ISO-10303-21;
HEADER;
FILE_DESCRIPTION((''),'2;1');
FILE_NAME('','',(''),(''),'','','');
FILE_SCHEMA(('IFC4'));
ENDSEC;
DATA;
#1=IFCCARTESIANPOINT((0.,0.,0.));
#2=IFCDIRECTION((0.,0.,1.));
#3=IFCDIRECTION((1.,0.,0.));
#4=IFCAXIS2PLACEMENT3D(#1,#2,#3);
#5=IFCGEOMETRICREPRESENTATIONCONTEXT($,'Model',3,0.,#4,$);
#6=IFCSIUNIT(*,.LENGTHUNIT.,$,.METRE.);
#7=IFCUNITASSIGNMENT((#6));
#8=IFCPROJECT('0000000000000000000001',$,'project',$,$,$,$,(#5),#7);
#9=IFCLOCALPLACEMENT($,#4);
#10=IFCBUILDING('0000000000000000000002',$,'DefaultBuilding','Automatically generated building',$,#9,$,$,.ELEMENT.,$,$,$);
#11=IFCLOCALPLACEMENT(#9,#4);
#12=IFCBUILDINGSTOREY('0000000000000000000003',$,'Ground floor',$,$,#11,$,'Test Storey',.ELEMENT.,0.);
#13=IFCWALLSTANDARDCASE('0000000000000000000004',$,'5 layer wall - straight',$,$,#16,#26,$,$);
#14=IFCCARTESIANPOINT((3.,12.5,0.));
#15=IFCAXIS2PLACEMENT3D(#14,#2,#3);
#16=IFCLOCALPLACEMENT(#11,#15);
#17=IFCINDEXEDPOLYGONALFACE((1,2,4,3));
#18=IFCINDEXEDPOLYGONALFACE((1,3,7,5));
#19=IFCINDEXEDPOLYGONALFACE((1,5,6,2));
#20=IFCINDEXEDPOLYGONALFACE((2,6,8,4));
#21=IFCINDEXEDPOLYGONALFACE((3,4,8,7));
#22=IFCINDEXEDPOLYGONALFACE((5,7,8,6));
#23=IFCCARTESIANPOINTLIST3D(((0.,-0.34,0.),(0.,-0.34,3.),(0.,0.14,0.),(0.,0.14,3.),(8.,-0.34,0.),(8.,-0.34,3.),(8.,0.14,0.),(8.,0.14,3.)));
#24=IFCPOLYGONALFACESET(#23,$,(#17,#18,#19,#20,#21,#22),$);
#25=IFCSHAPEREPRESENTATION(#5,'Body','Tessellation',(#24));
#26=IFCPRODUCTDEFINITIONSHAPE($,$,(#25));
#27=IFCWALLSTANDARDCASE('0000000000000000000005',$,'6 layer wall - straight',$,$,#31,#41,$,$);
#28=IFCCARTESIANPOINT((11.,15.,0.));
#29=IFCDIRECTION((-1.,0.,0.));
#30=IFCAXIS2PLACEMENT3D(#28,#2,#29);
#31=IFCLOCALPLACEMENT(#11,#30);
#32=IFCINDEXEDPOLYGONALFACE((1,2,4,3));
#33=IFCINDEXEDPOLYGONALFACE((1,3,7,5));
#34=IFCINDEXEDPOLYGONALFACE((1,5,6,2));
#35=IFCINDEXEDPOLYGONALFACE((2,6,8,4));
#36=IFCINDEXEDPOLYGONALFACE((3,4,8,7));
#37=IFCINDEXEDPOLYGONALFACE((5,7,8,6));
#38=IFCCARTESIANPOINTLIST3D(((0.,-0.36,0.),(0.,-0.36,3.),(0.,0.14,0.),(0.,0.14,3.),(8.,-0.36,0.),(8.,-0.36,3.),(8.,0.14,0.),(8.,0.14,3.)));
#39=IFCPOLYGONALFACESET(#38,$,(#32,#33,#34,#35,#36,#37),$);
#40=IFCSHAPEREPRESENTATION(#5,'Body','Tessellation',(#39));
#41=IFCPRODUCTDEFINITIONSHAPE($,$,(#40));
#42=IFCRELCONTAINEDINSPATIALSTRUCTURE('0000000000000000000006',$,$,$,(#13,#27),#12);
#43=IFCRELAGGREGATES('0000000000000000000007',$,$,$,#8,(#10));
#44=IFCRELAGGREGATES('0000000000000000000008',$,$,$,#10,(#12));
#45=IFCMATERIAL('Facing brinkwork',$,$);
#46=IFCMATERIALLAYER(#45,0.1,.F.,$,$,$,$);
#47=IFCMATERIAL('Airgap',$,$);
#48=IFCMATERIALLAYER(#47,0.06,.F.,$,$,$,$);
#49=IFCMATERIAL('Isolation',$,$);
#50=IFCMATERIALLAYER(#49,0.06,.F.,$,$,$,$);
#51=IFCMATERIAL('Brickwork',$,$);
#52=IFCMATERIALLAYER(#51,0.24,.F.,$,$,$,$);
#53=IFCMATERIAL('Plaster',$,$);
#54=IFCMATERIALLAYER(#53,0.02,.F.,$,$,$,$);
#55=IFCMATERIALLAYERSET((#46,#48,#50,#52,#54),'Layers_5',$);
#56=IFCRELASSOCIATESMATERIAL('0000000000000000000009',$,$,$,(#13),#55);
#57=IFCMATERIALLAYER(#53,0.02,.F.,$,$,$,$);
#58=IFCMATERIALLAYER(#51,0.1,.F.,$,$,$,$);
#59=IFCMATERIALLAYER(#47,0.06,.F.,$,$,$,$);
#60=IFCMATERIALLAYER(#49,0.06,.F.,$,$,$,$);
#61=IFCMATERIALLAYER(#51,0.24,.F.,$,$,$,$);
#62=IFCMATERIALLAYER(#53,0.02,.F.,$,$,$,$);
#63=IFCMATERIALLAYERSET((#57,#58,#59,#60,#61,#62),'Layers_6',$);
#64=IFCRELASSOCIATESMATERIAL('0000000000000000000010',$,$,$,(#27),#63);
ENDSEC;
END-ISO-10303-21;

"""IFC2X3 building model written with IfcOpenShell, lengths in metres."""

from ifc_helpers import new_model, si_unit, frame, origin_with_axes, place, context, project, spatial, polyline, outline, extrude, material, layer, layer_set, layer_usage, element, save


model = new_model("IFC2X3")

# Units and contexts
model_context = context("Model", 3, precision=0.0, world=origin_with_axes())
ifc_project = project(units=[si_unit("LENGTHUNIT", "METRE")], contexts=[model_context])

# Building, storey
building_placement = place(None, origin_with_axes())
building = spatial("IfcBuilding", under=ifc_project, at=building_placement, Name="DefaultBuilding", Description="Automatically generated building", CompositionType="ELEMENT")
storey_placement = place(building_placement, origin_with_axes())
storey = spatial("IfcBuildingStorey", under=building, at=storey_placement, Name="Ground floor", LongName="Test Storey", CompositionType="ELEMENT", Elevation=0.0)

# Walls
ifc_material_1 = material(Name="Isolation")
ifc_material_2 = material(Name="Facing brinkwork")
ifc_layer_1 = layer(ifc_material_2, 0.1, ventilated=False)
ifc_material_3 = material(Name="Airgap")
ifc_layer_2 = layer(ifc_material_3, 0.06, ventilated=False)
ifc_layer_3 = layer(ifc_material_1, 0.06, ventilated=False)
ifc_material_4 = material(Name="Brickwork")
ifc_layer_4 = layer(ifc_material_4, 0.24, ventilated=False)
ifc_material_5 = material(Name="Plaster")
ifc_layer_5 = layer(ifc_material_5, 0.02, ventilated=False)
ifc_layer_set_1 = layer_set([ifc_layer_1, ifc_layer_2, ifc_layer_3, ifc_layer_4, ifc_layer_5], Name="Layers_5")
ifc_layer_usage_1 = layer_usage(ifc_layer_set_1, "AXIS2", "POSITIVE", -0.34)
wall_1_placement = place(storey_placement, frame((3.0, 12.5, 0.0), z_axis=(0.0, 0.0, 1.0), x_axis=(1.0, 0.0, 0.0)))
element("IfcWallStandardCase", 1, at=wall_1_placement, inside=storey, material=ifc_layer_usage_1, Name="5 layer wall - straight", context=model_context, shape_type="SweptSolid", body=[
    extrude(outline(polyline([(0.0, -0.34), (8.0, -0.34), (8.0, 0.14), (0.0, 0.14), (0.0, -0.34)])), origin_with_axes(), (0.0, 0.0, 1.0), 3.0),
])
ifc_layer_6 = layer(ifc_material_5, 0.02, ventilated=False)
ifc_layer_7 = layer(ifc_material_4, 0.1, ventilated=False)
ifc_layer_8 = layer(ifc_material_3, 0.06, ventilated=False)
ifc_layer_9 = layer(ifc_material_1, 0.06, ventilated=False)
ifc_layer_10 = layer(ifc_material_4, 0.24, ventilated=False)
ifc_layer_11 = layer(ifc_material_5, 0.02, ventilated=False)
ifc_layer_set_2 = layer_set([ifc_layer_6, ifc_layer_7, ifc_layer_8, ifc_layer_9, ifc_layer_10, ifc_layer_11], Name="Layers_6")
ifc_layer_usage_2 = layer_usage(ifc_layer_set_2, "AXIS2", "POSITIVE", -0.36)
wall_2_placement = place(storey_placement, frame((11.0, 15.0, 0.0), z_axis=(0.0, 0.0, 1.0), x_axis=(-1.0, 0.0, 0.0)))
element("IfcWallStandardCase", 2, at=wall_2_placement, inside=storey, material=ifc_layer_usage_2, Name="6 layer wall - straight", context=model_context, shape_type="SweptSolid", body=[
    extrude(outline(polyline([(0.0, -0.36), (8.0, -0.36), (8.0, 0.14), (0.0, 0.14), (0.0, -0.36)])), origin_with_axes(), (0.0, 0.0, 1.0), 3.0),
])

save(model, "model.ifc")
